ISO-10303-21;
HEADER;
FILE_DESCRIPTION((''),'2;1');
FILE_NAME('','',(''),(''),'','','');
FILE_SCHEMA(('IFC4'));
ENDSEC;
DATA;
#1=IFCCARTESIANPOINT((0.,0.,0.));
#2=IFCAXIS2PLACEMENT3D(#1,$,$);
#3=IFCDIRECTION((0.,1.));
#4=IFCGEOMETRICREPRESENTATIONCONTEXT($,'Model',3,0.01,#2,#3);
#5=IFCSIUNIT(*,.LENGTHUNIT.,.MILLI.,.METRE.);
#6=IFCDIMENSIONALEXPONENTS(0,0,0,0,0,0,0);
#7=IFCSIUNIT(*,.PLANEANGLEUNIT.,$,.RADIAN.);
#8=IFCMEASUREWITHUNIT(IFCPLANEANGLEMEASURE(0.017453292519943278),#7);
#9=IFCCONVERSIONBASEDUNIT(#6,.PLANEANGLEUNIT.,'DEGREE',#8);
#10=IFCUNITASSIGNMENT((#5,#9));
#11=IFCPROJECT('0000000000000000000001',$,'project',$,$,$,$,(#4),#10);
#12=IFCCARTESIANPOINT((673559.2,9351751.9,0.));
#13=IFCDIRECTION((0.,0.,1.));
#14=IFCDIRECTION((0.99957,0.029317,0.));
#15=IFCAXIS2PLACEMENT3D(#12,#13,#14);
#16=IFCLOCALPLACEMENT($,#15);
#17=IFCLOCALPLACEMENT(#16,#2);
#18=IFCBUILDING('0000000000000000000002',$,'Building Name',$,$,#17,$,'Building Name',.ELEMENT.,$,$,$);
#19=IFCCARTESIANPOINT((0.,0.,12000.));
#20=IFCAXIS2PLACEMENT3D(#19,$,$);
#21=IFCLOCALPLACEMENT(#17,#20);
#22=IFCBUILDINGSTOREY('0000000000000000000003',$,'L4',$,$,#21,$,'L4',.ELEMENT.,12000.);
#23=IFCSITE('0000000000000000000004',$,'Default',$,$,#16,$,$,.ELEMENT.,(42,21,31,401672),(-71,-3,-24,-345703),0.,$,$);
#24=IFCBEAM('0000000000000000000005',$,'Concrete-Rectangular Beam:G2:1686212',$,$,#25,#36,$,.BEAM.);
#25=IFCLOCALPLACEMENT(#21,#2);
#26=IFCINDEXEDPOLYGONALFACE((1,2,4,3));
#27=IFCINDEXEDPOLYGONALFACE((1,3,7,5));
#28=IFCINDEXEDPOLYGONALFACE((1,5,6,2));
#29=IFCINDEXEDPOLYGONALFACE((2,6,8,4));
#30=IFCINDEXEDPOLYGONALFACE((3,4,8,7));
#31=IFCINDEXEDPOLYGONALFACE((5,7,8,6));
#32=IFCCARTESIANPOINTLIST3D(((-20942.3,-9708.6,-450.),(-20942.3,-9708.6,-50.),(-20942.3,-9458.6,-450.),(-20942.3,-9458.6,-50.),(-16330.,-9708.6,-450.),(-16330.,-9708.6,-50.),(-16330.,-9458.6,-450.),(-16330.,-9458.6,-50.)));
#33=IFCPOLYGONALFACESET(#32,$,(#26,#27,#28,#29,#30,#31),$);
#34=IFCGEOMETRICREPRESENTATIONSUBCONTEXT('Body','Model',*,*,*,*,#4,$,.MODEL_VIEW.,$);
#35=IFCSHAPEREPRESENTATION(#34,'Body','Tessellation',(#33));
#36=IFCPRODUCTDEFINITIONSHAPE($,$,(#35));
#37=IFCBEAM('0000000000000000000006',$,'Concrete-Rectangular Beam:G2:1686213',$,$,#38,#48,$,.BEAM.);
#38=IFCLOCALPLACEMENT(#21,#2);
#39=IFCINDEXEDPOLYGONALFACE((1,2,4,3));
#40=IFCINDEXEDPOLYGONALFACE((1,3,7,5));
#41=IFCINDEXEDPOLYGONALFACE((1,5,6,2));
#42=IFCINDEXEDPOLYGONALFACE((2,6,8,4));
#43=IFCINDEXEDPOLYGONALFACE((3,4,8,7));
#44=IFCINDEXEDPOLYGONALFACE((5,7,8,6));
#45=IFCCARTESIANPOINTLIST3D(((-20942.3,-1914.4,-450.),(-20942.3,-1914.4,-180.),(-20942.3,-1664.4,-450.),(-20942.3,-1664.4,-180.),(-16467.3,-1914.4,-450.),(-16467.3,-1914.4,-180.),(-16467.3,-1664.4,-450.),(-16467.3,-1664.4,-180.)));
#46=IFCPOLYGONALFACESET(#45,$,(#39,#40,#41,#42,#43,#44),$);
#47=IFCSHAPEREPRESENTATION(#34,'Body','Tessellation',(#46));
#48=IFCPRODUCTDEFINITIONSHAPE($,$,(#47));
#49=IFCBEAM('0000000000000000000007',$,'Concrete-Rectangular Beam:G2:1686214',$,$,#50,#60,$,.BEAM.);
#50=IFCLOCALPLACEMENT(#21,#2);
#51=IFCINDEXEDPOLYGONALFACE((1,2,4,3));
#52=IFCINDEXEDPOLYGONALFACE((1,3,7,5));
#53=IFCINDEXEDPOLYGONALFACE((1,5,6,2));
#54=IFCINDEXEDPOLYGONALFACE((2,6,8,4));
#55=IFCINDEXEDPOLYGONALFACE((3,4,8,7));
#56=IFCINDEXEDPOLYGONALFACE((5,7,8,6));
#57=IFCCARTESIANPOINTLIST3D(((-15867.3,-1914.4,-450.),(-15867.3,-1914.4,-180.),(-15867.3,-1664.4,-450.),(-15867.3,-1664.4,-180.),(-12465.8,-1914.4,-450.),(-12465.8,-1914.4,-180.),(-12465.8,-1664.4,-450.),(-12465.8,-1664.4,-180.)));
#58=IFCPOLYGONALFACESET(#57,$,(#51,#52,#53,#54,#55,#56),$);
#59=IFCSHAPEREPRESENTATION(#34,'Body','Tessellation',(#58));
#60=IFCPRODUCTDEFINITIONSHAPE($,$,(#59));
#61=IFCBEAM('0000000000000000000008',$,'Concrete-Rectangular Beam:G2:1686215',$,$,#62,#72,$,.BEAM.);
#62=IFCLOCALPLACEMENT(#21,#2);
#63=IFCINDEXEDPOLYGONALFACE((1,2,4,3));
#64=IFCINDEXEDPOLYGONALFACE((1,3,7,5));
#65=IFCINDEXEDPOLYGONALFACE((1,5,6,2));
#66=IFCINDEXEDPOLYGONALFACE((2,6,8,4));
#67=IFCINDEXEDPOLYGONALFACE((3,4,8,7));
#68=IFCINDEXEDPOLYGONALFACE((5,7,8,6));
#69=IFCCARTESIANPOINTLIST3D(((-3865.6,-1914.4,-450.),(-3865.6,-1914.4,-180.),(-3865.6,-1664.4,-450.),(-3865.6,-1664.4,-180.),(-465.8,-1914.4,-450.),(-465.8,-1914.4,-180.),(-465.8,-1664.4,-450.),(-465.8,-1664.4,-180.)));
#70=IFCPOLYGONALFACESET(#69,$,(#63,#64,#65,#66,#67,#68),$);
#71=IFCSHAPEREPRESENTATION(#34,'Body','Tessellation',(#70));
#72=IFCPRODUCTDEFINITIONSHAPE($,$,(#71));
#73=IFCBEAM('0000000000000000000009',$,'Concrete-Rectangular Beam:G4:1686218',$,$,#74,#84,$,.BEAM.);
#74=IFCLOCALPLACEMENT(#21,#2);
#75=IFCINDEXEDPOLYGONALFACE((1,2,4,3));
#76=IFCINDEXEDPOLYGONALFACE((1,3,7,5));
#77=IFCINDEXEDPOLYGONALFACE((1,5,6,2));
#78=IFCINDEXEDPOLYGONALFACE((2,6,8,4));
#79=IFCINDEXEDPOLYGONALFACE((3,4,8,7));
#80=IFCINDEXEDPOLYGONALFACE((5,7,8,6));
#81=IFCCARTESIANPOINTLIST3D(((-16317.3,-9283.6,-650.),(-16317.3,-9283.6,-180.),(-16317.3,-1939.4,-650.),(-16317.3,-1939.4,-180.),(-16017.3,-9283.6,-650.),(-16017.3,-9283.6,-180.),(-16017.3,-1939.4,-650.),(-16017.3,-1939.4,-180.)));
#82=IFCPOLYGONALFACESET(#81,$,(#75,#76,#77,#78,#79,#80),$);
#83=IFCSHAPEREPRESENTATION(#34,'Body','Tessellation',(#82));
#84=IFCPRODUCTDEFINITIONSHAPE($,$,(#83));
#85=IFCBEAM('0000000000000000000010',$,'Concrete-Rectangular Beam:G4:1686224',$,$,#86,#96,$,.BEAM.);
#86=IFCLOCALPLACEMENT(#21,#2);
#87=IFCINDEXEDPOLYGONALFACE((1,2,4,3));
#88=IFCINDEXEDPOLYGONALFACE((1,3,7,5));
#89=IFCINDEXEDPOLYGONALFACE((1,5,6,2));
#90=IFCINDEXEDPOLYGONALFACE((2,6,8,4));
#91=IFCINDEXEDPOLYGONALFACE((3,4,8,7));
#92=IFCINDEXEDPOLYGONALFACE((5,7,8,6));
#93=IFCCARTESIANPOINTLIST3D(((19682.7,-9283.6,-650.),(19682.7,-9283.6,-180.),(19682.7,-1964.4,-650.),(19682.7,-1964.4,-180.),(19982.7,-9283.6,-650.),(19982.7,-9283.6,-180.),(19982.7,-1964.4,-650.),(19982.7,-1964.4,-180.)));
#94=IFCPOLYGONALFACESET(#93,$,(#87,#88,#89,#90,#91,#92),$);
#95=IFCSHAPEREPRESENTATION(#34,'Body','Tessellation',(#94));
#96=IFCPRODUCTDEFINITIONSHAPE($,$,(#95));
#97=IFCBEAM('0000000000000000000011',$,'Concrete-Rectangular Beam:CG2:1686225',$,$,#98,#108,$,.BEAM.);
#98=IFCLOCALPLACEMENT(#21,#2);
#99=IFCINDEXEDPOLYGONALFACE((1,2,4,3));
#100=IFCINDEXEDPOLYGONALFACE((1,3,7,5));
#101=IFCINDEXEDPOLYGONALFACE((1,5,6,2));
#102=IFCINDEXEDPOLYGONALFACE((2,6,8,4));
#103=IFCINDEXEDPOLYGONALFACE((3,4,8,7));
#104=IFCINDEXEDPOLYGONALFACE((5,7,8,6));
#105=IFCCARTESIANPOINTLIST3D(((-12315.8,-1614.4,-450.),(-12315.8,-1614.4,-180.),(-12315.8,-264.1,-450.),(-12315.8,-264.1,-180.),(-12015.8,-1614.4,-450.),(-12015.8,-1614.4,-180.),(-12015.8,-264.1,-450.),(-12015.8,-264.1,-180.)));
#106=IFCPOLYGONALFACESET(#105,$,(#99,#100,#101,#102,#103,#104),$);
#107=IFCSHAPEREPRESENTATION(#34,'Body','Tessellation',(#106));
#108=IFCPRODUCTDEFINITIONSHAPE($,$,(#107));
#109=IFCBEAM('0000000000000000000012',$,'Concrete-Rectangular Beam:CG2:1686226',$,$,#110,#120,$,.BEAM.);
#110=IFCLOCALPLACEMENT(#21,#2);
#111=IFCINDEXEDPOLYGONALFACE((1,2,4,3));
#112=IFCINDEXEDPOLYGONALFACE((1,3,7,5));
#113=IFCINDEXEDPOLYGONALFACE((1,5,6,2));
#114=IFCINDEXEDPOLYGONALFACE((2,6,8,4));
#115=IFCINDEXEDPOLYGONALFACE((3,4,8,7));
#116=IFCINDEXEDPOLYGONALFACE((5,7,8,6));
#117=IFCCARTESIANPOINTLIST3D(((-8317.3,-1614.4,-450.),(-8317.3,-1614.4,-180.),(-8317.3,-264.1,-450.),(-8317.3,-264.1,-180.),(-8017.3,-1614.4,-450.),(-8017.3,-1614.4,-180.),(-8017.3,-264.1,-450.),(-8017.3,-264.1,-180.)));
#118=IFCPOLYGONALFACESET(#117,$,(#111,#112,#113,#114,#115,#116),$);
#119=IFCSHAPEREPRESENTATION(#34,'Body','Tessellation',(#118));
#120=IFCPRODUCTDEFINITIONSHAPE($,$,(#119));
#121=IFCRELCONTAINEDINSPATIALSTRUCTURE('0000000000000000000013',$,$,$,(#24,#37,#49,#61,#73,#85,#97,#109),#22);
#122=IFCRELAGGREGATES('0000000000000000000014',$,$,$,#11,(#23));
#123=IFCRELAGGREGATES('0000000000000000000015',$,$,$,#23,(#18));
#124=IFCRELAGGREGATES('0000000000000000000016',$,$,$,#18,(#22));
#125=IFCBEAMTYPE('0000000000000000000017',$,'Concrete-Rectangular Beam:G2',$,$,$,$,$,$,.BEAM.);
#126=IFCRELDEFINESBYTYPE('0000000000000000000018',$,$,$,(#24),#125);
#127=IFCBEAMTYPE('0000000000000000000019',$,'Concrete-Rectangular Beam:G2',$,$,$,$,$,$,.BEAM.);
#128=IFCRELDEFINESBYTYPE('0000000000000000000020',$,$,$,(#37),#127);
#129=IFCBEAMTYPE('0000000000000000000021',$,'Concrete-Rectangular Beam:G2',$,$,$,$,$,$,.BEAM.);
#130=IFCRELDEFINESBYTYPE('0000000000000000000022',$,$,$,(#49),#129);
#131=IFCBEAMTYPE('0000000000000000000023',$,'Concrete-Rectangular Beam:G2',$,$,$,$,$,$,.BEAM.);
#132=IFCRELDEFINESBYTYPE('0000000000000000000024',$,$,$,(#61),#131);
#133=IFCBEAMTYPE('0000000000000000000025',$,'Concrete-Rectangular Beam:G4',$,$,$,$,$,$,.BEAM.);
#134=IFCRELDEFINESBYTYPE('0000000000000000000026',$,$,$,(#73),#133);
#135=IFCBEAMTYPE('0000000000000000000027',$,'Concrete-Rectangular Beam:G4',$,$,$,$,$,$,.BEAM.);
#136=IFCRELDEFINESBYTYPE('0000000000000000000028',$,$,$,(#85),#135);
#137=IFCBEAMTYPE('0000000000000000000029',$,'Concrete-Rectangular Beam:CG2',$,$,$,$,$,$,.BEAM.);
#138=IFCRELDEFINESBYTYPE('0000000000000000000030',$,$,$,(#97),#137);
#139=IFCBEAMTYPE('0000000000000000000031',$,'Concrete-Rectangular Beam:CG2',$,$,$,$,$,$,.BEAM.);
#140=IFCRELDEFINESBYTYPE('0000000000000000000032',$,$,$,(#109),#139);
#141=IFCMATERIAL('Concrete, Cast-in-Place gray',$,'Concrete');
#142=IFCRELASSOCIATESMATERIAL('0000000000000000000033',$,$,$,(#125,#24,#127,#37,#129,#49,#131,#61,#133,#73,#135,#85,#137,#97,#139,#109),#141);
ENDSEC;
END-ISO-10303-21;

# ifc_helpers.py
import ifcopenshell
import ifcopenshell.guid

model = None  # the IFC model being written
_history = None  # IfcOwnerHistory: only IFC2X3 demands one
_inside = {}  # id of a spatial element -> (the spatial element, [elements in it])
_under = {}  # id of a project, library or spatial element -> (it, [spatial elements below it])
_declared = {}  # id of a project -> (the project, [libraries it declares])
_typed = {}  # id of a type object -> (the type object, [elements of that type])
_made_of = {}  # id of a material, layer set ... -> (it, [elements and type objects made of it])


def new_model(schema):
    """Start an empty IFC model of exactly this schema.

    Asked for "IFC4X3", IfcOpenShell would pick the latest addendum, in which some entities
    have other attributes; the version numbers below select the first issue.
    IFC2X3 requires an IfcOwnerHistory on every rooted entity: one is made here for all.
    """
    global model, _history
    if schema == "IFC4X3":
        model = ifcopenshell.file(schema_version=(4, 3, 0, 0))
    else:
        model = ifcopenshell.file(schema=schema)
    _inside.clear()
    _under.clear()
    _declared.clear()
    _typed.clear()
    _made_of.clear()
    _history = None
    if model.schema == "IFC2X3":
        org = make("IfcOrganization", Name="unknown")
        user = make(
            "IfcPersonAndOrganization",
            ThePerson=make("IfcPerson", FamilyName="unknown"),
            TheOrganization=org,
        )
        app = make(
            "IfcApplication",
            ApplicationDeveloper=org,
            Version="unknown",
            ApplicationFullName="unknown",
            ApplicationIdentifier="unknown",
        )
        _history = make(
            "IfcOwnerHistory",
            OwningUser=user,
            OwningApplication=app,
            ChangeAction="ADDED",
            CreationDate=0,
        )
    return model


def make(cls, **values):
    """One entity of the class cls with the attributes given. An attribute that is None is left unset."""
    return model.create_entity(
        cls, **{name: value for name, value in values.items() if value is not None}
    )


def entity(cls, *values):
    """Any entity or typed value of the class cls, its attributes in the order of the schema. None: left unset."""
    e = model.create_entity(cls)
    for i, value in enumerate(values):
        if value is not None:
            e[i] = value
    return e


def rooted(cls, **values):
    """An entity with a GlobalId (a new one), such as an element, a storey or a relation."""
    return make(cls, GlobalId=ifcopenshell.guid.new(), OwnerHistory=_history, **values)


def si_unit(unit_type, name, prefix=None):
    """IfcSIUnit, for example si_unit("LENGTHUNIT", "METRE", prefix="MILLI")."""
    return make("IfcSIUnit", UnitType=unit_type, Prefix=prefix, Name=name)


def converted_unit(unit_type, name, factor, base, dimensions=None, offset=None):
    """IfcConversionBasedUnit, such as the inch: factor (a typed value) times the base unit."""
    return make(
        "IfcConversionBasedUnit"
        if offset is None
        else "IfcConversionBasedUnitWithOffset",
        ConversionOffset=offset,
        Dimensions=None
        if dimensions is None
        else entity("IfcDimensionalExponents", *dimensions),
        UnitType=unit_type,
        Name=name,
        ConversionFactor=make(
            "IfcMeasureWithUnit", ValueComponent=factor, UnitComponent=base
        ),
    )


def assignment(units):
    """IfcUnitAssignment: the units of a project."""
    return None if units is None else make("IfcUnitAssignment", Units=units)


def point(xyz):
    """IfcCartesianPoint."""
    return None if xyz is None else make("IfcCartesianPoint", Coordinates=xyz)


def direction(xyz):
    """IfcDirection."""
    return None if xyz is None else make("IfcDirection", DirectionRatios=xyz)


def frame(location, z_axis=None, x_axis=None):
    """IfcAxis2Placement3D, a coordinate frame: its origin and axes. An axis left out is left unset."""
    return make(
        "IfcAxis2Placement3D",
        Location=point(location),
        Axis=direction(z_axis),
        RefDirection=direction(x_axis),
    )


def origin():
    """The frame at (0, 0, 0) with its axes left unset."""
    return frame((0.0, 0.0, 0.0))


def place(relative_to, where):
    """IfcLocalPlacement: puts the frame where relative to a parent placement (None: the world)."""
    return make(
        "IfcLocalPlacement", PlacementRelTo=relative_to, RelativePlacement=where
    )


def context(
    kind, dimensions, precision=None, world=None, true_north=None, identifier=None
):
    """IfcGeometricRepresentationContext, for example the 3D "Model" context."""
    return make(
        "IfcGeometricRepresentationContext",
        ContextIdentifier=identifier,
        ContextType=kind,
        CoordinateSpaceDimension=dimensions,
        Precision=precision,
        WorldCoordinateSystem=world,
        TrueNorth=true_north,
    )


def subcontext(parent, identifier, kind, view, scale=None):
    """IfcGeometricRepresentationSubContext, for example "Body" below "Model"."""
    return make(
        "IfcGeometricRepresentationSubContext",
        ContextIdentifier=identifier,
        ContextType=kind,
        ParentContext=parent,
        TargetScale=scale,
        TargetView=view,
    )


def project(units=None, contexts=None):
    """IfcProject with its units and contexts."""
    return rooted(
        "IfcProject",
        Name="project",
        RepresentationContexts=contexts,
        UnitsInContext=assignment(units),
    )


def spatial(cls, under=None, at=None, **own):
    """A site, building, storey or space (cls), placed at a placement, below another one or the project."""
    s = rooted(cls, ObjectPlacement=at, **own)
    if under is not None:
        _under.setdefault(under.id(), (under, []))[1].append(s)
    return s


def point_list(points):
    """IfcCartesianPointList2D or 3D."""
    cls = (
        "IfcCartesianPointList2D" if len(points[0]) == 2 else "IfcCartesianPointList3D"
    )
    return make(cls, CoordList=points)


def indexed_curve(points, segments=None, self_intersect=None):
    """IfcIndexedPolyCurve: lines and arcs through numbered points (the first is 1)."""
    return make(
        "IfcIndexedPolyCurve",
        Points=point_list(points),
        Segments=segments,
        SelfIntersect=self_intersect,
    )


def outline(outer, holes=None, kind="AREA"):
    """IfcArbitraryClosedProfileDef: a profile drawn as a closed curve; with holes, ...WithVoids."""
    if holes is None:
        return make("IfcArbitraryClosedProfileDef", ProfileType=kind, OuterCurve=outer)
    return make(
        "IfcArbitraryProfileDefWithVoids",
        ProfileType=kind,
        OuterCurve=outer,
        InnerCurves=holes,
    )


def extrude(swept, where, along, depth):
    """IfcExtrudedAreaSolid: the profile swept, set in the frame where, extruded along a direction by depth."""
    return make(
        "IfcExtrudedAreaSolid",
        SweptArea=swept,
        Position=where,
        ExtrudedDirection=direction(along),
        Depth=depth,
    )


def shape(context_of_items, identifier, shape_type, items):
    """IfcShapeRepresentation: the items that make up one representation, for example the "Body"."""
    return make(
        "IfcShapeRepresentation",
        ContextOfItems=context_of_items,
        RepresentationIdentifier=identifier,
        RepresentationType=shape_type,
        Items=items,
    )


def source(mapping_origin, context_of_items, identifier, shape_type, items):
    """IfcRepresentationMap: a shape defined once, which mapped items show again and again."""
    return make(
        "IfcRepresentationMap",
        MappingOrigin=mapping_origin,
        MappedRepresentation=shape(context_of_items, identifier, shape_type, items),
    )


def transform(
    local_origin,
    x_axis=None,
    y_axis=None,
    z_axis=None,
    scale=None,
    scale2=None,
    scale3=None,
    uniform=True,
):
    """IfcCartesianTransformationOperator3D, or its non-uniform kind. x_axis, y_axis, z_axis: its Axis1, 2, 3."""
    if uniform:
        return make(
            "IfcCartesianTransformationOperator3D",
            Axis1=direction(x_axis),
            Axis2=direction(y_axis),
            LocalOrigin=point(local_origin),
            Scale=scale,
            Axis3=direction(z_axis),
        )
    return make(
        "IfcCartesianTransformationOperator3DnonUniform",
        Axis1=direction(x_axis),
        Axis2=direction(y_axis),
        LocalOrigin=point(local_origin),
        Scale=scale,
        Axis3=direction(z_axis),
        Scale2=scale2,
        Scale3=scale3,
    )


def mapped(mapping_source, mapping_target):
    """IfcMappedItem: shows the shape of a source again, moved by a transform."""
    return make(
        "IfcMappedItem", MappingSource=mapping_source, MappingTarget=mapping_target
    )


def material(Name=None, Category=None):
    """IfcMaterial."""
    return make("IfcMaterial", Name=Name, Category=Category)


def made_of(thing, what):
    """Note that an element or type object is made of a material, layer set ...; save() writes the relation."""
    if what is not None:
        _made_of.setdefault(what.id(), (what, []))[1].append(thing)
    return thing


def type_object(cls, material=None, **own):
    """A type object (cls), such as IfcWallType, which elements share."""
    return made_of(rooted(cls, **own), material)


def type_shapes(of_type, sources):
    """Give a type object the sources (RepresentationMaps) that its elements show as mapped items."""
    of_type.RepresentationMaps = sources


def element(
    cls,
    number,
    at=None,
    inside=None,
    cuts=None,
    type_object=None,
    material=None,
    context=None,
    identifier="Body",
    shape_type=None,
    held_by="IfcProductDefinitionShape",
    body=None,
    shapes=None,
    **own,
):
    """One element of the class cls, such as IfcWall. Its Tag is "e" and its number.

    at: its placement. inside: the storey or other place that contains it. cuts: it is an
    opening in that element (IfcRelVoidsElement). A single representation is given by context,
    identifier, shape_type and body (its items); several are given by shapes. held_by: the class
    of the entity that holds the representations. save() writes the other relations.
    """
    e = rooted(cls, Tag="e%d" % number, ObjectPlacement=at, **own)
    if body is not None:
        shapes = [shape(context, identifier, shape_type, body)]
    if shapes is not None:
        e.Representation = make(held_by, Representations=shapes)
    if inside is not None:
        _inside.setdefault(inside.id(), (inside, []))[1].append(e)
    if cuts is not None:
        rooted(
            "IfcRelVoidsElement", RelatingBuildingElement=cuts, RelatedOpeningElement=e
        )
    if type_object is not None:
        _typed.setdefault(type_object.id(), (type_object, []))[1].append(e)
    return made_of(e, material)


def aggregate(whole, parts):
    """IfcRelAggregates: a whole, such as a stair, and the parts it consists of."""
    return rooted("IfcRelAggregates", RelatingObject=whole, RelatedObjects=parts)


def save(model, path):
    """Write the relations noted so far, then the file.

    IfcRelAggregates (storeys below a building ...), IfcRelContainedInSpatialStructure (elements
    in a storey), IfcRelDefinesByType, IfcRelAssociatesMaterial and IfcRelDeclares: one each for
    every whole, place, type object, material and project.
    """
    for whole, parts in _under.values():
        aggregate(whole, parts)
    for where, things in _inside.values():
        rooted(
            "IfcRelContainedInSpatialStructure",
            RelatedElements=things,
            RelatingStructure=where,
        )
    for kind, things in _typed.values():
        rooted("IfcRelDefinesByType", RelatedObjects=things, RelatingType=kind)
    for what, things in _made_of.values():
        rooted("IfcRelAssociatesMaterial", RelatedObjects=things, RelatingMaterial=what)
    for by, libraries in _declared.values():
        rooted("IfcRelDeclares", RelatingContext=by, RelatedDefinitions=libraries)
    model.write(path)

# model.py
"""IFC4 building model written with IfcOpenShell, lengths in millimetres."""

from ifc_helpers import new_model, entity, si_unit, converted_unit, direction, frame, origin, place, context, subcontext, project, spatial, indexed_curve, outline, extrude, source, transform, mapped, material, type_object, type_shapes, element, save


model = new_model("IFC4")

# Units and contexts
model_context = context("Model", 3, precision=0.01, world=origin(), true_north=direction((0.0, 1.0)))
body_context = subcontext(model_context, "Body", "Model", "MODEL_VIEW")
ifc_project = project(units=[si_unit("LENGTHUNIT", "METRE", prefix="MILLI"), converted_unit("PLANEANGLEUNIT", "DEGREE", entity("IfcPlaneAngleMeasure", 0.017453292519943278), si_unit("PLANEANGLEUNIT", "RADIAN"), dimensions=[0, 0, 0, 0, 0, 0, 0])], contexts=[model_context])

# Site, building, storey
site_placement = place(None, frame((673559.2, 9351751.9, 0.0), z_axis=(0.0, 0.0, 1.0), x_axis=(0.99957, 0.029317, 0.0)))
site = spatial("IfcSite", under=ifc_project, at=site_placement, Name="Default", CompositionType="ELEMENT", RefLatitude=(42, 21, 31, 401672), RefLongitude=(-71, -3, -24, -345703), RefElevation=0.0)
building_placement = place(site_placement, origin())
building = spatial("IfcBuilding", under=site, at=building_placement, Name="Building Name", LongName="Building Name", CompositionType="ELEMENT")
storey_placement = place(building_placement, frame((0.0, 0.0, 12000.0)))
storey = spatial("IfcBuildingStorey", under=building, at=storey_placement, Name="L4", LongName="L4", CompositionType="ELEMENT", Elevation=12000.0)

# Shared definitions
ifc_material = material(Name="Concrete, Cast-in-Place gray", Category="Concrete")

# Beams
beam_type_1 = type_object("IfcBeamType", Name="Concrete-Rectangular Beam:G2", PredefinedType="BEAM", material=ifc_material)
shared_shape_1 = source(origin(), body_context, "Body", "SweptSolid", [
    extrude(outline(indexed_curve([(-200.0, -125.0), (200.0, -125.0), (200.0, 125.0), (-200.0, 125.0), (-200.0, -125.0)], self_intersect=False)), frame((-16330.0, -9583.6, 11750.0), z_axis=(-1.0, 0.0, 0.0), x_axis=(0.0, 0.0, -1.0)), (0.0, 0.0, 1.0), 4612.3),
])
type_shapes(beam_type_1, [shared_shape_1])
beam_1_placement = place(storey_placement, frame((0.0, 0.0, -12000.0)))
element("IfcBeam", 1, at=beam_1_placement, inside=storey, type_object=beam_type_1, material=ifc_material, Name="Concrete-Rectangular Beam:G2:1686212", PredefinedType="BEAM", context=body_context, shape_type="MappedRepresentation", body=[
    mapped(shared_shape_1, transform((0.0, 0.0, 0.0), scale=1.0)),
])
beam_type_2 = type_object("IfcBeamType", Name="Concrete-Rectangular Beam:G2", PredefinedType="BEAM", material=ifc_material)
shared_shape_2 = source(origin(), body_context, "Body", "SweptSolid", [
    extrude(outline(indexed_curve([(-135.0, -125.0), (135.0, -125.0), (135.0, 125.0), (-135.0, 125.0), (-135.0, -125.0)], self_intersect=False)), frame((-20942.3, -1789.4, 11685.0), z_axis=(1.0, 0.0, 0.0), x_axis=(0.0, 0.0, -1.0)), (0.0, 0.0, 1.0), 4475.0),
])
type_shapes(beam_type_2, [shared_shape_2])
beam_2_placement = place(storey_placement, frame((0.0, 0.0, -12000.0)))
element("IfcBeam", 2, at=beam_2_placement, inside=storey, type_object=beam_type_2, material=ifc_material, Name="Concrete-Rectangular Beam:G2:1686213", PredefinedType="BEAM", context=body_context, shape_type="MappedRepresentation", body=[
    mapped(shared_shape_2, transform((0.0, 0.0, 0.0), scale=1.0)),
])
beam_type_3 = type_object("IfcBeamType", Name="Concrete-Rectangular Beam:G2", PredefinedType="BEAM", material=ifc_material)
shared_shape_3 = source(origin(), body_context, "Body", "SweptSolid", [
    extrude(outline(indexed_curve([(-135.0, -125.0), (135.0, -125.0), (135.0, 125.0), (-135.0, 125.0), (-135.0, -125.0)], self_intersect=False)), frame((-15867.3, -1789.4, 11685.0), z_axis=(1.0, 0.0, 0.0), x_axis=(0.0, 0.0, -1.0)), (0.0, 0.0, 1.0), 3401.5),
])
type_shapes(beam_type_3, [shared_shape_3])
beam_3_placement = place(storey_placement, frame((0.0, 0.0, -12000.0)))
element("IfcBeam", 3, at=beam_3_placement, inside=storey, type_object=beam_type_3, material=ifc_material, Name="Concrete-Rectangular Beam:G2:1686214", PredefinedType="BEAM", context=body_context, shape_type="MappedRepresentation", body=[
    mapped(shared_shape_3, transform((0.0, 0.0, 0.0), scale=1.0)),
])
beam_type_4 = type_object("IfcBeamType", Name="Concrete-Rectangular Beam:G2", PredefinedType="BEAM", material=ifc_material)
shared_shape_4 = source(origin(), body_context, "Body", "SweptSolid", [
    extrude(outline(indexed_curve([(-135.0, -125.0), (135.0, -125.0), (135.0, 125.0), (-135.0, 125.0), (-135.0, -125.0)], self_intersect=False)), frame((-465.8, -1789.4, 11685.0), z_axis=(-1.0, 0.0, 0.0), x_axis=(0.0, 0.0, -1.0)), (0.0, 0.0, 1.0), 3399.7),
])
type_shapes(beam_type_4, [shared_shape_4])
beam_4_placement = place(storey_placement, frame((0.0, 0.0, -12000.0)))
element("IfcBeam", 4, at=beam_4_placement, inside=storey, type_object=beam_type_4, material=ifc_material, Name="Concrete-Rectangular Beam:G2:1686215", PredefinedType="BEAM", context=body_context, shape_type="MappedRepresentation", body=[
    mapped(shared_shape_4, transform((0.0, 0.0, 0.0), scale=1.0)),
])
beam_type_5 = type_object("IfcBeamType", Name="Concrete-Rectangular Beam:G4", PredefinedType="BEAM", material=ifc_material)
shared_shape_5 = source(origin(), body_context, "Body", "SweptSolid", [
    extrude(outline(indexed_curve([(-150.0, -235.0), (150.0, -235.0), (150.0, 235.0), (-150.0, 235.0), (-150.0, -235.0)], self_intersect=False)), frame((-16167.3, -9283.6, 11585.0), z_axis=(0.0, 1.0, 0.0), x_axis=(-1.0, 0.0, 0.0)), (0.0, 0.0, 1.0), 7344.1),
])
type_shapes(beam_type_5, [shared_shape_5])
beam_5_placement = place(storey_placement, frame((0.0, 0.0, -12000.0)))
element("IfcBeam", 5, at=beam_5_placement, inside=storey, type_object=beam_type_5, material=ifc_material, Name="Concrete-Rectangular Beam:G4:1686218", PredefinedType="BEAM", context=body_context, shape_type="MappedRepresentation", body=[
    mapped(shared_shape_5, transform((0.0, 0.0, 0.0), scale=1.0)),
])
beam_type_6 = type_object("IfcBeamType", Name="Concrete-Rectangular Beam:G4", PredefinedType="BEAM", material=ifc_material)
shared_shape_6 = source(origin(), body_context, "Body", "SweptSolid", [
    extrude(outline(indexed_curve([(-150.0, -235.0), (150.0, -235.0), (150.0, 235.0), (-150.0, 235.0), (-150.0, -235.0)], self_intersect=False)), frame((19832.7, -9283.6, 11585.0), z_axis=(0.0, 1.0, 0.0), x_axis=(-1.0, 0.0, 0.0)), (0.0, 0.0, 1.0), 7319.1),
])
type_shapes(beam_type_6, [shared_shape_6])
beam_6_placement = place(storey_placement, frame((0.0, 0.0, -12000.0)))
element("IfcBeam", 6, at=beam_6_placement, inside=storey, type_object=beam_type_6, material=ifc_material, Name="Concrete-Rectangular Beam:G4:1686224", PredefinedType="BEAM", context=body_context, shape_type="MappedRepresentation", body=[
    mapped(shared_shape_6, transform((0.0, 0.0, 0.0), scale=1.0)),
])
beam_type_7 = type_object("IfcBeamType", Name="Concrete-Rectangular Beam:CG2", PredefinedType="BEAM", material=ifc_material)
shared_shape_7 = source(origin(), body_context, "Body", "SweptSolid", [
    extrude(outline(indexed_curve([(-150.0, -135.0), (150.0, -135.0), (150.0, 135.0), (-150.0, 135.0), (-150.0, -135.0)], self_intersect=False)), frame((-12165.8, -1614.4, 11685.0), z_axis=(0.0, 1.0, 0.0), x_axis=(-1.0, 0.0, 0.0)), (0.0, 0.0, 1.0), 1350.4),
])
type_shapes(beam_type_7, [shared_shape_7])
beam_7_placement = place(storey_placement, frame((0.0, 0.0, -12000.0)))
element("IfcBeam", 7, at=beam_7_placement, inside=storey, type_object=beam_type_7, material=ifc_material, Name="Concrete-Rectangular Beam:CG2:1686225", PredefinedType="BEAM", context=body_context, shape_type="MappedRepresentation", body=[
    mapped(shared_shape_7, transform((0.0, 0.0, 0.0), scale=1.0)),
])
beam_type_8 = type_object("IfcBeamType", Name="Concrete-Rectangular Beam:CG2", PredefinedType="BEAM", material=ifc_material)
shared_shape_8 = source(origin(), body_context, "Body", "SweptSolid", [
    extrude(outline(indexed_curve([(-150.0, -135.0), (150.0, -135.0), (150.0, 135.0), (-150.0, 135.0), (-150.0, -135.0)], self_intersect=False)), frame((-8167.3, -1614.4, 11685.0), z_axis=(0.0, 1.0, 0.0), x_axis=(-1.0, 0.0, 0.0)), (0.0, 0.0, 1.0), 1350.4),
])
type_shapes(beam_type_8, [shared_shape_8])
beam_8_placement = place(storey_placement, frame((0.0, 0.0, -12000.0)))
element("IfcBeam", 8, at=beam_8_placement, inside=storey, type_object=beam_type_8, material=ifc_material, Name="Concrete-Rectangular Beam:CG2:1686226", PredefinedType="BEAM", context=body_context, shape_type="MappedRepresentation", body=[
    mapped(shared_shape_8, transform((0.0, 0.0, 0.0), scale=1.0)),
])

save(model, "model.ifc")
